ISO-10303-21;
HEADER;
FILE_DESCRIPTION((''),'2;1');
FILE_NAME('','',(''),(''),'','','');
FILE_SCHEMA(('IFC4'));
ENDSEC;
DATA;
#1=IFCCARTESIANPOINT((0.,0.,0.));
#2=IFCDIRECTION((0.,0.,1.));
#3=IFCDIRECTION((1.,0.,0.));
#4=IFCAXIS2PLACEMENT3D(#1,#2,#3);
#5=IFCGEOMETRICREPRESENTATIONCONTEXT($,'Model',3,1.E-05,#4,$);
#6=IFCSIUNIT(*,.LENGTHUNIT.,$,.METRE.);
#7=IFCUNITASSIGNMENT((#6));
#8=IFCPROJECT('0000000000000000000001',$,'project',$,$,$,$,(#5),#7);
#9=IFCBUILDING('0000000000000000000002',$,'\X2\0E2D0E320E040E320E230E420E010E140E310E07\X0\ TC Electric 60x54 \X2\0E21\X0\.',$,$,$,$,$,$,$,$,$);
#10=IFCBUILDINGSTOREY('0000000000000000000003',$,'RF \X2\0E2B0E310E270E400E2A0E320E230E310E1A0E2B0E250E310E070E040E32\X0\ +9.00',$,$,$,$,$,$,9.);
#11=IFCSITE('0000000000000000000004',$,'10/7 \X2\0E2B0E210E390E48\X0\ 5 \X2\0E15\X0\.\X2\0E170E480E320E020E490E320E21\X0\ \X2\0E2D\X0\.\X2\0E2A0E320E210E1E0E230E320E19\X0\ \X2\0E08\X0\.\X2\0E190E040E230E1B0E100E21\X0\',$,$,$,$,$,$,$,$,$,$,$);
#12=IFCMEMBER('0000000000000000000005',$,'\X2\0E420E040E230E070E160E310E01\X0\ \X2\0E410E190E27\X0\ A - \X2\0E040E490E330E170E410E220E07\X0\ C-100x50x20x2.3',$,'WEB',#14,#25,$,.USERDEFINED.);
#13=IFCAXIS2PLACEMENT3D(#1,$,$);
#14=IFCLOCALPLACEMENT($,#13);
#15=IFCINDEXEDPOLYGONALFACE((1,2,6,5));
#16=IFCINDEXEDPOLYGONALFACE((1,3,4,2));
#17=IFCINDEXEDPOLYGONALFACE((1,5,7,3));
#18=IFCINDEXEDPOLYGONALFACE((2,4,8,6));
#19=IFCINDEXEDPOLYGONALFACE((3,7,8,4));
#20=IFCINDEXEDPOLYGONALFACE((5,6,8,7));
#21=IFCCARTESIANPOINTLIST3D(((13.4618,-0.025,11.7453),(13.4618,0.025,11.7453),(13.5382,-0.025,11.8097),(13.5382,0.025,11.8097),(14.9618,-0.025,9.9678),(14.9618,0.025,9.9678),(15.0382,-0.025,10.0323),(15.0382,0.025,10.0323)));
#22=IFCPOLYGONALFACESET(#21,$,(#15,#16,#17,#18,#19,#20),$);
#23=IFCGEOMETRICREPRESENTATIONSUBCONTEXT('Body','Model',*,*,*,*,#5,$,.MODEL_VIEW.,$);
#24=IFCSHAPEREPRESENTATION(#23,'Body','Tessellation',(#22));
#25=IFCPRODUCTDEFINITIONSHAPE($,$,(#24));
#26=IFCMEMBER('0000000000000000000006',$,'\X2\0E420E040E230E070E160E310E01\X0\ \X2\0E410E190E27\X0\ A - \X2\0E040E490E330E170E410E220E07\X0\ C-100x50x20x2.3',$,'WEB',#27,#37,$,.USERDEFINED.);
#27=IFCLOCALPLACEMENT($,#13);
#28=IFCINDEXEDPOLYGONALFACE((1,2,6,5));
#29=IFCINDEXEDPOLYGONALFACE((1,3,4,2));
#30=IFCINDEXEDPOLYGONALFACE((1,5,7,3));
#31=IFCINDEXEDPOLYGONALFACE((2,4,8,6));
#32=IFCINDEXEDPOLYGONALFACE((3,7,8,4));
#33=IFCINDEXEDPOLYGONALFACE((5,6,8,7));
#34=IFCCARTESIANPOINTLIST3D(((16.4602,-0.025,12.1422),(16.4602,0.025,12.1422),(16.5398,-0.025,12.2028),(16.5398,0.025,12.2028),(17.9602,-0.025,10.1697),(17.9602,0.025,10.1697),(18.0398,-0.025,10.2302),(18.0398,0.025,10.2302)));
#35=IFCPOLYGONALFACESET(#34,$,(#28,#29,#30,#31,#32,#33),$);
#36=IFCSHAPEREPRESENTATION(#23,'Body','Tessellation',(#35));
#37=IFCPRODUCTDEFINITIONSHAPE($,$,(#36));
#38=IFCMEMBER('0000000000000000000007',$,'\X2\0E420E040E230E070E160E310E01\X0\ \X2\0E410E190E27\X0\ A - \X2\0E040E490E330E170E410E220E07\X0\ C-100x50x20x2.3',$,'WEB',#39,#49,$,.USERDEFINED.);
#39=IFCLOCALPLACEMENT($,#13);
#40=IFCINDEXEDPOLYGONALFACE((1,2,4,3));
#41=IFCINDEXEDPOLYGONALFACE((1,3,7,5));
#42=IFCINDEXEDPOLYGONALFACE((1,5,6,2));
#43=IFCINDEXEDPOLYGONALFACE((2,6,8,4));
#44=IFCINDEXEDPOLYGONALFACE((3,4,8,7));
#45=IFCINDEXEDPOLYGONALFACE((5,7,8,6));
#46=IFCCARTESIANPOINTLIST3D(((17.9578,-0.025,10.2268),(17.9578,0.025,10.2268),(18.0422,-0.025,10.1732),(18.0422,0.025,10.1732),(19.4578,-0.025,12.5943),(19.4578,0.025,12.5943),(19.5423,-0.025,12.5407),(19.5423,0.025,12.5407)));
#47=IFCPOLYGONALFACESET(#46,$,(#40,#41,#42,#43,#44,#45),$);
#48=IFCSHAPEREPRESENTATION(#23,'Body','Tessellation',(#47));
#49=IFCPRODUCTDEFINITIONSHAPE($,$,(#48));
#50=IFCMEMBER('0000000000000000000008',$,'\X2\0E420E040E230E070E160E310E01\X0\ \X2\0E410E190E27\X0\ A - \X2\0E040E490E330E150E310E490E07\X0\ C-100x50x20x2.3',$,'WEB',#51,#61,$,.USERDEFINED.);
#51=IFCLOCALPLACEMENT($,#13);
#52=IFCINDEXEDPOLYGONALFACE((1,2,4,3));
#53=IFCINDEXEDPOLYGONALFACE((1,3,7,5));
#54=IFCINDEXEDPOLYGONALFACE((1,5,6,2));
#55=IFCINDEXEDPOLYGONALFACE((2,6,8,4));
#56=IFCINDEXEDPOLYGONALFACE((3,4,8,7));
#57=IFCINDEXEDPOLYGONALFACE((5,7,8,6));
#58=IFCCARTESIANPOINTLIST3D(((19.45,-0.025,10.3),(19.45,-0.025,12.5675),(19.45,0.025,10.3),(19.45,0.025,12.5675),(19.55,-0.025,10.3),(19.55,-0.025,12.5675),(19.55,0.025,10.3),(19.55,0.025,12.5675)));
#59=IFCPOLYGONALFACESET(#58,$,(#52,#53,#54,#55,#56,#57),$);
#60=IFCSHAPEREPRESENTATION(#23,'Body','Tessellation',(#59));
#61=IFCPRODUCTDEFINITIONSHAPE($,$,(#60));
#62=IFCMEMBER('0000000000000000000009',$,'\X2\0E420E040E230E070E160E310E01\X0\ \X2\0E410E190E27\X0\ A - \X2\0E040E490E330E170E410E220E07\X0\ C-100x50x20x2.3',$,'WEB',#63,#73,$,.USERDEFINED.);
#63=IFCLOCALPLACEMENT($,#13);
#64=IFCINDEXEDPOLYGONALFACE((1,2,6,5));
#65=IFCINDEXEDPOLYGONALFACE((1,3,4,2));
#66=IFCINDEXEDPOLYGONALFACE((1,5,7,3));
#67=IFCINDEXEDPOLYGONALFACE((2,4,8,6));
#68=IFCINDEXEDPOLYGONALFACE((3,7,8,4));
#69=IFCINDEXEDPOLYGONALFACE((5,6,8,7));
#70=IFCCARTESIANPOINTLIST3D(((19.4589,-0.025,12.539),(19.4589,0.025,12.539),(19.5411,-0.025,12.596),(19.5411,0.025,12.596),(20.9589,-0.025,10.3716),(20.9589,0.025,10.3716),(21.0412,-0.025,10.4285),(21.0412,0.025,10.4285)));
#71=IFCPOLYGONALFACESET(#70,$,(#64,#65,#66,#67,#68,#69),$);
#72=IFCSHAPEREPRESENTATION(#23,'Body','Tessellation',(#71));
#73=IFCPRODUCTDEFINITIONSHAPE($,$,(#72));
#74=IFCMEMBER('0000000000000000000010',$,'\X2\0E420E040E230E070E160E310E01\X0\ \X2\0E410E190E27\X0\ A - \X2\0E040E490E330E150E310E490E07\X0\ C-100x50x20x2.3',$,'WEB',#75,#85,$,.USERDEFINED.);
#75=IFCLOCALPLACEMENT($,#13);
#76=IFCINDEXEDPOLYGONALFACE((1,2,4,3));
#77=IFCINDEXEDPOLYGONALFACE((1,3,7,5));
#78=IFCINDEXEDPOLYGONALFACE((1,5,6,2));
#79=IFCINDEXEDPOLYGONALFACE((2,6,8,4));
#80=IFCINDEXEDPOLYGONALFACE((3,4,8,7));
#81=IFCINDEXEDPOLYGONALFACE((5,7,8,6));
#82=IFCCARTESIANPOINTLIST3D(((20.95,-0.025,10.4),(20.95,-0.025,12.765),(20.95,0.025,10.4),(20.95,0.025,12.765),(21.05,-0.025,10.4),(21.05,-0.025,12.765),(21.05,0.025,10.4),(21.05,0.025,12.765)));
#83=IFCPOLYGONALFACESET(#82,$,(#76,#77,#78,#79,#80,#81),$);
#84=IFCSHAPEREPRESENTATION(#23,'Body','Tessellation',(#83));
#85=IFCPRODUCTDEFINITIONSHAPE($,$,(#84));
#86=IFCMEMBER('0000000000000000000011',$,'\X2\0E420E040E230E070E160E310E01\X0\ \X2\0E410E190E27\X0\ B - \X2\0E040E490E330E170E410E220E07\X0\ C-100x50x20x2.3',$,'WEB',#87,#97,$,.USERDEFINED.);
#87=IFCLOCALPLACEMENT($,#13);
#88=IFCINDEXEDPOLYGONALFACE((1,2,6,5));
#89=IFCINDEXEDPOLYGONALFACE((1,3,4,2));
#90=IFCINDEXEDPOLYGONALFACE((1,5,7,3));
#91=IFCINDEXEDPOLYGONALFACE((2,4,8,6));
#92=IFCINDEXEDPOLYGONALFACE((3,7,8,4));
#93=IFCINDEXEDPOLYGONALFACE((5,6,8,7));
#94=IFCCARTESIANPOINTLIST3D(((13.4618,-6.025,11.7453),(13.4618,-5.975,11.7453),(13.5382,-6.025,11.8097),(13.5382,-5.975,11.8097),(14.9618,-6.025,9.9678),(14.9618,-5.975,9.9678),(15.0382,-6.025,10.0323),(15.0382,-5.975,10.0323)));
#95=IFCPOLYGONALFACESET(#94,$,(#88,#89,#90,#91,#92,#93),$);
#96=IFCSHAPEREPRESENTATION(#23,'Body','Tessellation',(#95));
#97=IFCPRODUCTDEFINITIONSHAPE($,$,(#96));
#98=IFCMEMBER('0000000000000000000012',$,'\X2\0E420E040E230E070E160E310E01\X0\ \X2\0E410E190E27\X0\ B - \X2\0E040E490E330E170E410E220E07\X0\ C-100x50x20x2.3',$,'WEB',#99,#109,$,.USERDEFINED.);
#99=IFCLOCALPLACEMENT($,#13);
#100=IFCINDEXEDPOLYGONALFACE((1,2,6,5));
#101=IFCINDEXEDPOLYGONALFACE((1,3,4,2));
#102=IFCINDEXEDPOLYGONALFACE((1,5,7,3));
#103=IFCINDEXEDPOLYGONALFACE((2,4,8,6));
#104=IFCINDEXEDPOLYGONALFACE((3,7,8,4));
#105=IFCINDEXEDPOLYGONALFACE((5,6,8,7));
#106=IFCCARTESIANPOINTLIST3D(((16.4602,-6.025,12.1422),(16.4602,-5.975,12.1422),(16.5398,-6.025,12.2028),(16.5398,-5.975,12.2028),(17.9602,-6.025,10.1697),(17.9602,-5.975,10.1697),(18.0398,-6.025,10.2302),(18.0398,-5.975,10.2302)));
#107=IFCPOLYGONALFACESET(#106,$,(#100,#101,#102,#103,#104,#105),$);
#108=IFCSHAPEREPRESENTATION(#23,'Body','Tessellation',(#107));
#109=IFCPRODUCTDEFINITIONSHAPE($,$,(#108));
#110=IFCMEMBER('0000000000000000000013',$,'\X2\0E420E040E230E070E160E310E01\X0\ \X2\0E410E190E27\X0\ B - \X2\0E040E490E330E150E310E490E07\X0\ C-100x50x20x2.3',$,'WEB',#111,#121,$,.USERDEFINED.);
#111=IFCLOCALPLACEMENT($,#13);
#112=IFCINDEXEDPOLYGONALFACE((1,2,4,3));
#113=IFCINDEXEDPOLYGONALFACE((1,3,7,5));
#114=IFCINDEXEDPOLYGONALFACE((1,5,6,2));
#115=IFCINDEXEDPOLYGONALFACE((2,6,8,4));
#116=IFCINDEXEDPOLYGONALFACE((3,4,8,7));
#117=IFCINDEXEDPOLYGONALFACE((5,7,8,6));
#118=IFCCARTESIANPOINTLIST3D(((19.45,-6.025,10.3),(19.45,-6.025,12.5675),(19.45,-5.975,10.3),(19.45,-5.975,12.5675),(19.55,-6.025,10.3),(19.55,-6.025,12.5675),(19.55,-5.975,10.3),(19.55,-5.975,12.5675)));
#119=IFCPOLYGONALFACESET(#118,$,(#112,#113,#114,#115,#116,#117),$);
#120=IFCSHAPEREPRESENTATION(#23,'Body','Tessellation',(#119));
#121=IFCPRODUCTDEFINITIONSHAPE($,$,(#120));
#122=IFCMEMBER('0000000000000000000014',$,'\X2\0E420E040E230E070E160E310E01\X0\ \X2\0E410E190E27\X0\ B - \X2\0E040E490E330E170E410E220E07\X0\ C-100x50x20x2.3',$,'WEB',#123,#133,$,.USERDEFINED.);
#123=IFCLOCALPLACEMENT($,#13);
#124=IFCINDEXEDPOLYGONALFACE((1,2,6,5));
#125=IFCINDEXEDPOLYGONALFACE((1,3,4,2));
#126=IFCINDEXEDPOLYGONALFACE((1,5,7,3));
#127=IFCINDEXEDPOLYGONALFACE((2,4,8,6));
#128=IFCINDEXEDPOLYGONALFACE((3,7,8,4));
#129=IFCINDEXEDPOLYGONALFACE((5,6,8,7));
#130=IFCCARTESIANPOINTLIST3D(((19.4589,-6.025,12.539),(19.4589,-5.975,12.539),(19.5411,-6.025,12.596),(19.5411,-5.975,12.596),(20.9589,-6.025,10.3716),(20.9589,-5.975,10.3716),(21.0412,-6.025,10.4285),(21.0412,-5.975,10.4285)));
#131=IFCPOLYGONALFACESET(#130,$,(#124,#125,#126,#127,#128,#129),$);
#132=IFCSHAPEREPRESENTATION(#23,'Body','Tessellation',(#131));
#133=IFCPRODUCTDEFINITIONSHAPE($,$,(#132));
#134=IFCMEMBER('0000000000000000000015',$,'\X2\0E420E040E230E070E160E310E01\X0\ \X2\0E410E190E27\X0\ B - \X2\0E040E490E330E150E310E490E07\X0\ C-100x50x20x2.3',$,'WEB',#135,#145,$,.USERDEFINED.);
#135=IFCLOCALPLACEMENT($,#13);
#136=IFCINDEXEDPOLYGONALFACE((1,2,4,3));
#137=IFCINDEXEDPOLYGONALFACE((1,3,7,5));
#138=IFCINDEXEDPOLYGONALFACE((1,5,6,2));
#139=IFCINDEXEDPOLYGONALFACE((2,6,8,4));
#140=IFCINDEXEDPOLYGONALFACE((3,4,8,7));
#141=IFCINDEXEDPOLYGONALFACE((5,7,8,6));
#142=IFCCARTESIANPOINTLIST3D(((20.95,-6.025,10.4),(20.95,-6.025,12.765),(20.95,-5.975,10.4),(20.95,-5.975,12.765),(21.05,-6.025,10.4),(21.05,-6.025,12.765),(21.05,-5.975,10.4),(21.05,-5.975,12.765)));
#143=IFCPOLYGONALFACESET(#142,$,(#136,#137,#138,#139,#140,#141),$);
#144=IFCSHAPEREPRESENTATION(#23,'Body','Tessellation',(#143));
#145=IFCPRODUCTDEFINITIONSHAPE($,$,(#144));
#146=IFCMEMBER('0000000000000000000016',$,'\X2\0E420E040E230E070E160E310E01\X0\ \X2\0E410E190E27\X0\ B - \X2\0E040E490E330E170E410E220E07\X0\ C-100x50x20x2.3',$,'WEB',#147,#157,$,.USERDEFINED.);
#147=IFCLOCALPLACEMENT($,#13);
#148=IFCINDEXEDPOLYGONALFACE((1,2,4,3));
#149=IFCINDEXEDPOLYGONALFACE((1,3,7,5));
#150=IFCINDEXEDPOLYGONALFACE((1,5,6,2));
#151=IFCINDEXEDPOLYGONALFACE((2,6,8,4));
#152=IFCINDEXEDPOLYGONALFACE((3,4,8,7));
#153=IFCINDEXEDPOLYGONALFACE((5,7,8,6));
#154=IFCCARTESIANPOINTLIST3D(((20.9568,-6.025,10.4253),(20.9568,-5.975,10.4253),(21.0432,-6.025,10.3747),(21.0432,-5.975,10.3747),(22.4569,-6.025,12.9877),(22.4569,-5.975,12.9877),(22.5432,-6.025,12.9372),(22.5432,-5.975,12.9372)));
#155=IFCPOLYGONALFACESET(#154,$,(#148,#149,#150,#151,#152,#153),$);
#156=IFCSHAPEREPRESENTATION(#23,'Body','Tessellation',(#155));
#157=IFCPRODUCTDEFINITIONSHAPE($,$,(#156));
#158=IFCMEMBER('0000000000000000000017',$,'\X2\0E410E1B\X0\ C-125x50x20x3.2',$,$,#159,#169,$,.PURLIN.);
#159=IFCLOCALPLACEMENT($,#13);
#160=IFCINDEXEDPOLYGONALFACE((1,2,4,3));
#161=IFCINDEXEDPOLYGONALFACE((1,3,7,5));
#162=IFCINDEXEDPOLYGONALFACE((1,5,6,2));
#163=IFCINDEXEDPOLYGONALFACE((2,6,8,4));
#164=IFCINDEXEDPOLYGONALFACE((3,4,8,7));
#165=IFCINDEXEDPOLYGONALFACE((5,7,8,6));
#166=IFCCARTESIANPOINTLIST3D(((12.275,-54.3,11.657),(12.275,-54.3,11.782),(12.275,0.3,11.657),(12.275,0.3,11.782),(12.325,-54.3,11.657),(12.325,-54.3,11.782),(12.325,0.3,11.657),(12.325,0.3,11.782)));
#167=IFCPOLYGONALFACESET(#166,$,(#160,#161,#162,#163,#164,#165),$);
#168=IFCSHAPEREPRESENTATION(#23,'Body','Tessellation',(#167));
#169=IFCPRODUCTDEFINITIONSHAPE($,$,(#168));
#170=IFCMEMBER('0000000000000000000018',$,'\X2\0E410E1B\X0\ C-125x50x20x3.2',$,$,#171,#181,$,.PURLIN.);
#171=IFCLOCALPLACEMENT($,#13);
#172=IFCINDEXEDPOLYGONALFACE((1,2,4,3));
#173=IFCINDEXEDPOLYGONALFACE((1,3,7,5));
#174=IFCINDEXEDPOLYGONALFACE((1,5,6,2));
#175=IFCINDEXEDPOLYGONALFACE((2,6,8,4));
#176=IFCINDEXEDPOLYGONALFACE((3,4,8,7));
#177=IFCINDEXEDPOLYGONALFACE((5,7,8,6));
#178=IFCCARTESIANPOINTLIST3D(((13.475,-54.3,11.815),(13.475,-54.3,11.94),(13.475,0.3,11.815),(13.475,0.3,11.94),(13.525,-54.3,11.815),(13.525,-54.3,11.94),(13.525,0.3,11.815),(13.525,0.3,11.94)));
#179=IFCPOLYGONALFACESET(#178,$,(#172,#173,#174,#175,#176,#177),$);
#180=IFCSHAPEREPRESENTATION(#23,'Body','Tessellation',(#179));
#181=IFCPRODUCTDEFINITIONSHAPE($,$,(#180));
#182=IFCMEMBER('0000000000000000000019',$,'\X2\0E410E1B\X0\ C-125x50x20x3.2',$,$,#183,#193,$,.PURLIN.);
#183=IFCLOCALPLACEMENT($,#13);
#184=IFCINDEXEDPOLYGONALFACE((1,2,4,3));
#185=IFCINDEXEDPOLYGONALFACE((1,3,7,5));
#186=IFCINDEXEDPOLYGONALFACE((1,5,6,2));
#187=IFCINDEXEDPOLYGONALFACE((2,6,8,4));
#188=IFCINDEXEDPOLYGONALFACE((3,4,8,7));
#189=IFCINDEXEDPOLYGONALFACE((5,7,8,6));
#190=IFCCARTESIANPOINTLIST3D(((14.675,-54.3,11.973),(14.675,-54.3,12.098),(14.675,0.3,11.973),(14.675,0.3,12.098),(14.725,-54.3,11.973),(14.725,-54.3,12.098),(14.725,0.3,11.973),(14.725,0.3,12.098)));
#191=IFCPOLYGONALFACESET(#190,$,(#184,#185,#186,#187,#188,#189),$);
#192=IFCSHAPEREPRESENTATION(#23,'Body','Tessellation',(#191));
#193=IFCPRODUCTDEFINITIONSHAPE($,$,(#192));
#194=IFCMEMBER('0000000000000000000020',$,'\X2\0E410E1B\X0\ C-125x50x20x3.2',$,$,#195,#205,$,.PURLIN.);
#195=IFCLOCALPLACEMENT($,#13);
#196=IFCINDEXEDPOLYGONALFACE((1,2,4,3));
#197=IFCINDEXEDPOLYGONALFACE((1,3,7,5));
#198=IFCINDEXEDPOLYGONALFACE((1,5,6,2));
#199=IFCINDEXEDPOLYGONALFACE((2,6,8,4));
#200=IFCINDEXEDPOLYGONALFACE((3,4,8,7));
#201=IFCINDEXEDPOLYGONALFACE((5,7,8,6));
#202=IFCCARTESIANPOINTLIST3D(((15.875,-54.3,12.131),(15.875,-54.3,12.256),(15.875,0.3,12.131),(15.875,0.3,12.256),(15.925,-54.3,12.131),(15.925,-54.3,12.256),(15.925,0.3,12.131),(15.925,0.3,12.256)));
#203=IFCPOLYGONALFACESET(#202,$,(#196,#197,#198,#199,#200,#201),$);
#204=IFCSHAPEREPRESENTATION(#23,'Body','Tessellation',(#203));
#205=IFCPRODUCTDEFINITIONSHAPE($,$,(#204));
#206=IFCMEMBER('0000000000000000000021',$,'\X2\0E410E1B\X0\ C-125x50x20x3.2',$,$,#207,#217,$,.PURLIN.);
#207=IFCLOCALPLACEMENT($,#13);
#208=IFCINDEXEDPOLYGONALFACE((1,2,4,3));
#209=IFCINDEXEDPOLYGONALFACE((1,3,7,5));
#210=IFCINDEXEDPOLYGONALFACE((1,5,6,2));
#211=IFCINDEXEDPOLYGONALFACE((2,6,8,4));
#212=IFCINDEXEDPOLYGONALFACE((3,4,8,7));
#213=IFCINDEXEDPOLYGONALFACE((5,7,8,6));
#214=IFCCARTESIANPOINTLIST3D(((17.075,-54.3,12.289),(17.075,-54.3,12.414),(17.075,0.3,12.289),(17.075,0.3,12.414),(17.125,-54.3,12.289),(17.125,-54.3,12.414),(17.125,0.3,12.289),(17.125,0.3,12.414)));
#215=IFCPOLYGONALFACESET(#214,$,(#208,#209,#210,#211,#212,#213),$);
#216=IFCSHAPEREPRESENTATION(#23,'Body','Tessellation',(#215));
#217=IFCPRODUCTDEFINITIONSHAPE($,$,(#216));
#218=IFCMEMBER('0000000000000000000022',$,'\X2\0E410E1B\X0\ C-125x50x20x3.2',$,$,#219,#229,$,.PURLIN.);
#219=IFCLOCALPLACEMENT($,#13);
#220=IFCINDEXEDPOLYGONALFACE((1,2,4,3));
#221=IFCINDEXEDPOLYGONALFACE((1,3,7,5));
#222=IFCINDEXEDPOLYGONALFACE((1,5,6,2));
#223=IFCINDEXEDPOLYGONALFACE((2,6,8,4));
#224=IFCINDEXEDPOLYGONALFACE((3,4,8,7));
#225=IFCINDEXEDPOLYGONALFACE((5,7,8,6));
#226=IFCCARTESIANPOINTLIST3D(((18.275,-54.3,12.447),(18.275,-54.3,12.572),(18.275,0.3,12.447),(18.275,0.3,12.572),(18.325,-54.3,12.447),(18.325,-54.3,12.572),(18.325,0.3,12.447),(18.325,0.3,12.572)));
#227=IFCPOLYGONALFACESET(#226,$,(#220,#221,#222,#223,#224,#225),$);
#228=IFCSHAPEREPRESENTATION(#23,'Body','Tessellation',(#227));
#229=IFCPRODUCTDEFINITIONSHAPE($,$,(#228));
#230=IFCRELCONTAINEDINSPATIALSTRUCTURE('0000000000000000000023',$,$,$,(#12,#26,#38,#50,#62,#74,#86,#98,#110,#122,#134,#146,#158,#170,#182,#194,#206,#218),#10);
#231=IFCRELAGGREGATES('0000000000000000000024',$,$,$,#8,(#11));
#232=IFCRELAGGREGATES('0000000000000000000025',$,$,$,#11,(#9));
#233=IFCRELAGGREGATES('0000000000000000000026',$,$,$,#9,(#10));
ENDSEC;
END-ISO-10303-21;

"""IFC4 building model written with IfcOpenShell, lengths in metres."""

from ifc_helpers import new_model, si_unit, frame, origin, origin_with_axes, origin_2d, place, context, subcontext, project, spatial, rectangle, extrude, element, save


model = new_model("IFC4")

# Units and contexts
model_context = context("Model", 3, precision=1e-05, world=origin_with_axes())
body_context = subcontext(model_context, "Body", "Model", "MODEL_VIEW")
ifc_project = project(units=[si_unit("LENGTHUNIT", "METRE")], contexts=[model_context])

# Site, building, storey
site = spatial("IfcSite", under=ifc_project, Name="10/7 หมู่ 5 ต.ท่าข้าม อ.สามพราน จ.นครปฐม")
building = spatial("IfcBuilding", under=site, Name="อาคารโกดัง TC Electric 60x54 ม.")
storey = spatial("IfcBuildingStorey", under=building, Name="RF หัวเสารับหลังคา +9.00", Elevation=9.0)

# Members
member_1_placement = place(None, frame((13.5, 0.0, 11.7775), z_axis=(0.6449, 0.0, -0.7642), x_axis=(0.0, -1.0, 0.0)))
element("IfcMember", 1, at=member_1_placement, inside=storey, Name="โครงถัก แนว A - ค้ำทแยง C-100x50x20x2.3", ObjectType="WEB", PredefinedType="USERDEFINED", context=body_context, shape_type="SweptSolid", body=[
    extrude(rectangle(XDim=0.05, YDim=0.1, at=origin_2d()), origin(), (0.0, 0.0, 1.0), 2.3258),
])
member_2_placement = place(None, frame((16.5, 0.0, 12.1725), z_axis=(0.6053, 0.0, -0.796), x_axis=(0.0, -1.0, 0.0)))
element("IfcMember", 2, at=member_2_placement, inside=storey, Name="โครงถัก แนว A - ค้ำทแยง C-100x50x20x2.3", ObjectType="WEB", PredefinedType="USERDEFINED", context=body_context, shape_type="SweptSolid", body=[
    extrude(rectangle(XDim=0.05, YDim=0.1, at=origin_2d()), origin(), (0.0, 0.0, 1.0), 2.4781),
])
member_3_placement = place(None, frame((18.0, 0.0, 10.2), z_axis=(0.5352, 0.0, 0.8447), x_axis=(0.0, -1.0, 0.0)))
element("IfcMember", 3, at=member_3_placement, inside=storey, Name="โครงถัก แนว A - ค้ำทแยง C-100x50x20x2.3", ObjectType="WEB", PredefinedType="USERDEFINED", context=body_context, shape_type="SweptSolid", body=[
    extrude(rectangle(XDim=0.05, YDim=0.1, at=origin_2d()), origin(), (0.0, 0.0, 1.0), 2.8027),
])
member_4_placement = place(None, frame((19.5, 0.0, 10.3), z_axis=(0.0, 0.0, 1.0), x_axis=(0.0, 1.0, 0.0)))
element("IfcMember", 4, at=member_4_placement, inside=storey, Name="โครงถัก แนว A - ค้ำตั้ง C-100x50x20x2.3", ObjectType="WEB", PredefinedType="USERDEFINED", context=body_context, shape_type="SweptSolid", body=[
    extrude(rectangle(XDim=0.05, YDim=0.1, at=origin_2d()), origin(), (0.0, 0.0, 1.0), 2.2675),
])
member_5_placement = place(None, frame((19.5, 0.0, 12.5675), z_axis=(0.5691, 0.0, -0.8223), x_axis=(0.0, -1.0, 0.0)))
element("IfcMember", 5, at=member_5_placement, inside=storey, Name="โครงถัก แนว A - ค้ำทแยง C-100x50x20x2.3", ObjectType="WEB", PredefinedType="USERDEFINED", context=body_context, shape_type="SweptSolid", body=[
    extrude(rectangle(XDim=0.05, YDim=0.1, at=origin_2d()), origin(), (0.0, 0.0, 1.0), 2.6359),
])
member_6_placement = place(None, frame((21.0, 0.0, 10.4), z_axis=(0.0, 0.0, 1.0), x_axis=(0.0, 1.0, 0.0)))
element("IfcMember", 6, at=member_6_placement, inside=storey, Name="โครงถัก แนว A - ค้ำตั้ง C-100x50x20x2.3", ObjectType="WEB", PredefinedType="USERDEFINED", context=body_context, shape_type="SweptSolid", body=[
    extrude(rectangle(XDim=0.05, YDim=0.1, at=origin_2d()), origin(), (0.0, 0.0, 1.0), 2.365),
])
member_7_placement = place(None, frame((13.5, -6.0, 11.7775), z_axis=(0.6449, 0.0, -0.7642), x_axis=(0.0, -1.0, 0.0)))
element("IfcMember", 7, at=member_7_placement, inside=storey, Name="โครงถัก แนว B - ค้ำทแยง C-100x50x20x2.3", ObjectType="WEB", PredefinedType="USERDEFINED", context=body_context, shape_type="SweptSolid", body=[
    extrude(rectangle(XDim=0.05, YDim=0.1, at=origin_2d()), origin(), (0.0, 0.0, 1.0), 2.3258),
])
member_8_placement = place(None, frame((16.5, -6.0, 12.1725), z_axis=(0.6053, 0.0, -0.796), x_axis=(0.0, -1.0, 0.0)))
element("IfcMember", 8, at=member_8_placement, inside=storey, Name="โครงถัก แนว B - ค้ำทแยง C-100x50x20x2.3", ObjectType="WEB", PredefinedType="USERDEFINED", context=body_context, shape_type="SweptSolid", body=[
    extrude(rectangle(XDim=0.05, YDim=0.1, at=origin_2d()), origin(), (0.0, 0.0, 1.0), 2.4781),
])
member_9_placement = place(None, frame((19.5, -6.0, 10.3), z_axis=(0.0, 0.0, 1.0), x_axis=(0.0, 1.0, 0.0)))
element("IfcMember", 9, at=member_9_placement, inside=storey, Name="โครงถัก แนว B - ค้ำตั้ง C-100x50x20x2.3", ObjectType="WEB", PredefinedType="USERDEFINED", context=body_context, shape_type="SweptSolid", body=[
    extrude(rectangle(XDim=0.05, YDim=0.1, at=origin_2d()), origin(), (0.0, 0.0, 1.0), 2.2675),
])
member_10_placement = place(None, frame((19.5, -6.0, 12.5675), z_axis=(0.5691, 0.0, -0.8223), x_axis=(0.0, -1.0, 0.0)))
element("IfcMember", 10, at=member_10_placement, inside=storey, Name="โครงถัก แนว B - ค้ำทแยง C-100x50x20x2.3", ObjectType="WEB", PredefinedType="USERDEFINED", context=body_context, shape_type="SweptSolid", body=[
    extrude(rectangle(XDim=0.05, YDim=0.1, at=origin_2d()), origin(), (0.0, 0.0, 1.0), 2.6359),
])
member_11_placement = place(None, frame((21.0, -6.0, 10.4), z_axis=(0.0, 0.0, 1.0), x_axis=(0.0, 1.0, 0.0)))
element("IfcMember", 11, at=member_11_placement, inside=storey, Name="โครงถัก แนว B - ค้ำตั้ง C-100x50x20x2.3", ObjectType="WEB", PredefinedType="USERDEFINED", context=body_context, shape_type="SweptSolid", body=[
    extrude(rectangle(XDim=0.05, YDim=0.1, at=origin_2d()), origin(), (0.0, 0.0, 1.0), 2.365),
])
member_12_placement = place(None, frame((21.0, -6.0, 10.4), z_axis=(0.5052, 0.0, 0.863), x_axis=(0.0, -1.0, 0.0)))
element("IfcMember", 12, at=member_12_placement, inside=storey, Name="โครงถัก แนว B - ค้ำทแยง C-100x50x20x2.3", ObjectType="WEB", PredefinedType="USERDEFINED", context=body_context, shape_type="SweptSolid", body=[
    extrude(rectangle(XDim=0.05, YDim=0.1, at=origin_2d()), origin(), (0.0, 0.0, 1.0), 2.9692),
])
for number, where, z_axis, x_axis, name in (
    (13, (12.3, 0.3, 11.7195), (0.0, -1.0, 0.0), (-1.0, 0.0, 0.0), "แป C-125x50x20x3.2"),
    (14, (13.5, 0.3, 11.8775), (0.0, -1.0, 0.0), (-1.0, 0.0, 0.0), "แป C-125x50x20x3.2"),
    (15, (14.7, 0.3, 12.0355), (0.0, -1.0, 0.0), (-1.0, 0.0, 0.0), "แป C-125x50x20x3.2"),
    (16, (15.9, 0.3, 12.1935), (0.0, -1.0, 0.0), (-1.0, 0.0, 0.0), "แป C-125x50x20x3.2"),
    (17, (17.1, 0.3, 12.3515), (0.0, -1.0, 0.0), (-1.0, 0.0, 0.0), "แป C-125x50x20x3.2"),
    (18, (18.3, 0.3, 12.5095), (0.0, -1.0, 0.0), (-1.0, 0.0, 0.0), "แป C-125x50x20x3.2"),
):
    element("IfcMember", number, at=place(None, frame(where, z_axis=z_axis, x_axis=x_axis)), inside=storey, Name=name, PredefinedType="PURLIN", context=body_context, shape_type="SweptSolid", body=[
        extrude(rectangle(XDim=0.05, YDim=0.125, at=origin_2d()), origin(), (0.0, 0.0, 1.0), 54.6),
    ])

save(model, "model.ifc")
